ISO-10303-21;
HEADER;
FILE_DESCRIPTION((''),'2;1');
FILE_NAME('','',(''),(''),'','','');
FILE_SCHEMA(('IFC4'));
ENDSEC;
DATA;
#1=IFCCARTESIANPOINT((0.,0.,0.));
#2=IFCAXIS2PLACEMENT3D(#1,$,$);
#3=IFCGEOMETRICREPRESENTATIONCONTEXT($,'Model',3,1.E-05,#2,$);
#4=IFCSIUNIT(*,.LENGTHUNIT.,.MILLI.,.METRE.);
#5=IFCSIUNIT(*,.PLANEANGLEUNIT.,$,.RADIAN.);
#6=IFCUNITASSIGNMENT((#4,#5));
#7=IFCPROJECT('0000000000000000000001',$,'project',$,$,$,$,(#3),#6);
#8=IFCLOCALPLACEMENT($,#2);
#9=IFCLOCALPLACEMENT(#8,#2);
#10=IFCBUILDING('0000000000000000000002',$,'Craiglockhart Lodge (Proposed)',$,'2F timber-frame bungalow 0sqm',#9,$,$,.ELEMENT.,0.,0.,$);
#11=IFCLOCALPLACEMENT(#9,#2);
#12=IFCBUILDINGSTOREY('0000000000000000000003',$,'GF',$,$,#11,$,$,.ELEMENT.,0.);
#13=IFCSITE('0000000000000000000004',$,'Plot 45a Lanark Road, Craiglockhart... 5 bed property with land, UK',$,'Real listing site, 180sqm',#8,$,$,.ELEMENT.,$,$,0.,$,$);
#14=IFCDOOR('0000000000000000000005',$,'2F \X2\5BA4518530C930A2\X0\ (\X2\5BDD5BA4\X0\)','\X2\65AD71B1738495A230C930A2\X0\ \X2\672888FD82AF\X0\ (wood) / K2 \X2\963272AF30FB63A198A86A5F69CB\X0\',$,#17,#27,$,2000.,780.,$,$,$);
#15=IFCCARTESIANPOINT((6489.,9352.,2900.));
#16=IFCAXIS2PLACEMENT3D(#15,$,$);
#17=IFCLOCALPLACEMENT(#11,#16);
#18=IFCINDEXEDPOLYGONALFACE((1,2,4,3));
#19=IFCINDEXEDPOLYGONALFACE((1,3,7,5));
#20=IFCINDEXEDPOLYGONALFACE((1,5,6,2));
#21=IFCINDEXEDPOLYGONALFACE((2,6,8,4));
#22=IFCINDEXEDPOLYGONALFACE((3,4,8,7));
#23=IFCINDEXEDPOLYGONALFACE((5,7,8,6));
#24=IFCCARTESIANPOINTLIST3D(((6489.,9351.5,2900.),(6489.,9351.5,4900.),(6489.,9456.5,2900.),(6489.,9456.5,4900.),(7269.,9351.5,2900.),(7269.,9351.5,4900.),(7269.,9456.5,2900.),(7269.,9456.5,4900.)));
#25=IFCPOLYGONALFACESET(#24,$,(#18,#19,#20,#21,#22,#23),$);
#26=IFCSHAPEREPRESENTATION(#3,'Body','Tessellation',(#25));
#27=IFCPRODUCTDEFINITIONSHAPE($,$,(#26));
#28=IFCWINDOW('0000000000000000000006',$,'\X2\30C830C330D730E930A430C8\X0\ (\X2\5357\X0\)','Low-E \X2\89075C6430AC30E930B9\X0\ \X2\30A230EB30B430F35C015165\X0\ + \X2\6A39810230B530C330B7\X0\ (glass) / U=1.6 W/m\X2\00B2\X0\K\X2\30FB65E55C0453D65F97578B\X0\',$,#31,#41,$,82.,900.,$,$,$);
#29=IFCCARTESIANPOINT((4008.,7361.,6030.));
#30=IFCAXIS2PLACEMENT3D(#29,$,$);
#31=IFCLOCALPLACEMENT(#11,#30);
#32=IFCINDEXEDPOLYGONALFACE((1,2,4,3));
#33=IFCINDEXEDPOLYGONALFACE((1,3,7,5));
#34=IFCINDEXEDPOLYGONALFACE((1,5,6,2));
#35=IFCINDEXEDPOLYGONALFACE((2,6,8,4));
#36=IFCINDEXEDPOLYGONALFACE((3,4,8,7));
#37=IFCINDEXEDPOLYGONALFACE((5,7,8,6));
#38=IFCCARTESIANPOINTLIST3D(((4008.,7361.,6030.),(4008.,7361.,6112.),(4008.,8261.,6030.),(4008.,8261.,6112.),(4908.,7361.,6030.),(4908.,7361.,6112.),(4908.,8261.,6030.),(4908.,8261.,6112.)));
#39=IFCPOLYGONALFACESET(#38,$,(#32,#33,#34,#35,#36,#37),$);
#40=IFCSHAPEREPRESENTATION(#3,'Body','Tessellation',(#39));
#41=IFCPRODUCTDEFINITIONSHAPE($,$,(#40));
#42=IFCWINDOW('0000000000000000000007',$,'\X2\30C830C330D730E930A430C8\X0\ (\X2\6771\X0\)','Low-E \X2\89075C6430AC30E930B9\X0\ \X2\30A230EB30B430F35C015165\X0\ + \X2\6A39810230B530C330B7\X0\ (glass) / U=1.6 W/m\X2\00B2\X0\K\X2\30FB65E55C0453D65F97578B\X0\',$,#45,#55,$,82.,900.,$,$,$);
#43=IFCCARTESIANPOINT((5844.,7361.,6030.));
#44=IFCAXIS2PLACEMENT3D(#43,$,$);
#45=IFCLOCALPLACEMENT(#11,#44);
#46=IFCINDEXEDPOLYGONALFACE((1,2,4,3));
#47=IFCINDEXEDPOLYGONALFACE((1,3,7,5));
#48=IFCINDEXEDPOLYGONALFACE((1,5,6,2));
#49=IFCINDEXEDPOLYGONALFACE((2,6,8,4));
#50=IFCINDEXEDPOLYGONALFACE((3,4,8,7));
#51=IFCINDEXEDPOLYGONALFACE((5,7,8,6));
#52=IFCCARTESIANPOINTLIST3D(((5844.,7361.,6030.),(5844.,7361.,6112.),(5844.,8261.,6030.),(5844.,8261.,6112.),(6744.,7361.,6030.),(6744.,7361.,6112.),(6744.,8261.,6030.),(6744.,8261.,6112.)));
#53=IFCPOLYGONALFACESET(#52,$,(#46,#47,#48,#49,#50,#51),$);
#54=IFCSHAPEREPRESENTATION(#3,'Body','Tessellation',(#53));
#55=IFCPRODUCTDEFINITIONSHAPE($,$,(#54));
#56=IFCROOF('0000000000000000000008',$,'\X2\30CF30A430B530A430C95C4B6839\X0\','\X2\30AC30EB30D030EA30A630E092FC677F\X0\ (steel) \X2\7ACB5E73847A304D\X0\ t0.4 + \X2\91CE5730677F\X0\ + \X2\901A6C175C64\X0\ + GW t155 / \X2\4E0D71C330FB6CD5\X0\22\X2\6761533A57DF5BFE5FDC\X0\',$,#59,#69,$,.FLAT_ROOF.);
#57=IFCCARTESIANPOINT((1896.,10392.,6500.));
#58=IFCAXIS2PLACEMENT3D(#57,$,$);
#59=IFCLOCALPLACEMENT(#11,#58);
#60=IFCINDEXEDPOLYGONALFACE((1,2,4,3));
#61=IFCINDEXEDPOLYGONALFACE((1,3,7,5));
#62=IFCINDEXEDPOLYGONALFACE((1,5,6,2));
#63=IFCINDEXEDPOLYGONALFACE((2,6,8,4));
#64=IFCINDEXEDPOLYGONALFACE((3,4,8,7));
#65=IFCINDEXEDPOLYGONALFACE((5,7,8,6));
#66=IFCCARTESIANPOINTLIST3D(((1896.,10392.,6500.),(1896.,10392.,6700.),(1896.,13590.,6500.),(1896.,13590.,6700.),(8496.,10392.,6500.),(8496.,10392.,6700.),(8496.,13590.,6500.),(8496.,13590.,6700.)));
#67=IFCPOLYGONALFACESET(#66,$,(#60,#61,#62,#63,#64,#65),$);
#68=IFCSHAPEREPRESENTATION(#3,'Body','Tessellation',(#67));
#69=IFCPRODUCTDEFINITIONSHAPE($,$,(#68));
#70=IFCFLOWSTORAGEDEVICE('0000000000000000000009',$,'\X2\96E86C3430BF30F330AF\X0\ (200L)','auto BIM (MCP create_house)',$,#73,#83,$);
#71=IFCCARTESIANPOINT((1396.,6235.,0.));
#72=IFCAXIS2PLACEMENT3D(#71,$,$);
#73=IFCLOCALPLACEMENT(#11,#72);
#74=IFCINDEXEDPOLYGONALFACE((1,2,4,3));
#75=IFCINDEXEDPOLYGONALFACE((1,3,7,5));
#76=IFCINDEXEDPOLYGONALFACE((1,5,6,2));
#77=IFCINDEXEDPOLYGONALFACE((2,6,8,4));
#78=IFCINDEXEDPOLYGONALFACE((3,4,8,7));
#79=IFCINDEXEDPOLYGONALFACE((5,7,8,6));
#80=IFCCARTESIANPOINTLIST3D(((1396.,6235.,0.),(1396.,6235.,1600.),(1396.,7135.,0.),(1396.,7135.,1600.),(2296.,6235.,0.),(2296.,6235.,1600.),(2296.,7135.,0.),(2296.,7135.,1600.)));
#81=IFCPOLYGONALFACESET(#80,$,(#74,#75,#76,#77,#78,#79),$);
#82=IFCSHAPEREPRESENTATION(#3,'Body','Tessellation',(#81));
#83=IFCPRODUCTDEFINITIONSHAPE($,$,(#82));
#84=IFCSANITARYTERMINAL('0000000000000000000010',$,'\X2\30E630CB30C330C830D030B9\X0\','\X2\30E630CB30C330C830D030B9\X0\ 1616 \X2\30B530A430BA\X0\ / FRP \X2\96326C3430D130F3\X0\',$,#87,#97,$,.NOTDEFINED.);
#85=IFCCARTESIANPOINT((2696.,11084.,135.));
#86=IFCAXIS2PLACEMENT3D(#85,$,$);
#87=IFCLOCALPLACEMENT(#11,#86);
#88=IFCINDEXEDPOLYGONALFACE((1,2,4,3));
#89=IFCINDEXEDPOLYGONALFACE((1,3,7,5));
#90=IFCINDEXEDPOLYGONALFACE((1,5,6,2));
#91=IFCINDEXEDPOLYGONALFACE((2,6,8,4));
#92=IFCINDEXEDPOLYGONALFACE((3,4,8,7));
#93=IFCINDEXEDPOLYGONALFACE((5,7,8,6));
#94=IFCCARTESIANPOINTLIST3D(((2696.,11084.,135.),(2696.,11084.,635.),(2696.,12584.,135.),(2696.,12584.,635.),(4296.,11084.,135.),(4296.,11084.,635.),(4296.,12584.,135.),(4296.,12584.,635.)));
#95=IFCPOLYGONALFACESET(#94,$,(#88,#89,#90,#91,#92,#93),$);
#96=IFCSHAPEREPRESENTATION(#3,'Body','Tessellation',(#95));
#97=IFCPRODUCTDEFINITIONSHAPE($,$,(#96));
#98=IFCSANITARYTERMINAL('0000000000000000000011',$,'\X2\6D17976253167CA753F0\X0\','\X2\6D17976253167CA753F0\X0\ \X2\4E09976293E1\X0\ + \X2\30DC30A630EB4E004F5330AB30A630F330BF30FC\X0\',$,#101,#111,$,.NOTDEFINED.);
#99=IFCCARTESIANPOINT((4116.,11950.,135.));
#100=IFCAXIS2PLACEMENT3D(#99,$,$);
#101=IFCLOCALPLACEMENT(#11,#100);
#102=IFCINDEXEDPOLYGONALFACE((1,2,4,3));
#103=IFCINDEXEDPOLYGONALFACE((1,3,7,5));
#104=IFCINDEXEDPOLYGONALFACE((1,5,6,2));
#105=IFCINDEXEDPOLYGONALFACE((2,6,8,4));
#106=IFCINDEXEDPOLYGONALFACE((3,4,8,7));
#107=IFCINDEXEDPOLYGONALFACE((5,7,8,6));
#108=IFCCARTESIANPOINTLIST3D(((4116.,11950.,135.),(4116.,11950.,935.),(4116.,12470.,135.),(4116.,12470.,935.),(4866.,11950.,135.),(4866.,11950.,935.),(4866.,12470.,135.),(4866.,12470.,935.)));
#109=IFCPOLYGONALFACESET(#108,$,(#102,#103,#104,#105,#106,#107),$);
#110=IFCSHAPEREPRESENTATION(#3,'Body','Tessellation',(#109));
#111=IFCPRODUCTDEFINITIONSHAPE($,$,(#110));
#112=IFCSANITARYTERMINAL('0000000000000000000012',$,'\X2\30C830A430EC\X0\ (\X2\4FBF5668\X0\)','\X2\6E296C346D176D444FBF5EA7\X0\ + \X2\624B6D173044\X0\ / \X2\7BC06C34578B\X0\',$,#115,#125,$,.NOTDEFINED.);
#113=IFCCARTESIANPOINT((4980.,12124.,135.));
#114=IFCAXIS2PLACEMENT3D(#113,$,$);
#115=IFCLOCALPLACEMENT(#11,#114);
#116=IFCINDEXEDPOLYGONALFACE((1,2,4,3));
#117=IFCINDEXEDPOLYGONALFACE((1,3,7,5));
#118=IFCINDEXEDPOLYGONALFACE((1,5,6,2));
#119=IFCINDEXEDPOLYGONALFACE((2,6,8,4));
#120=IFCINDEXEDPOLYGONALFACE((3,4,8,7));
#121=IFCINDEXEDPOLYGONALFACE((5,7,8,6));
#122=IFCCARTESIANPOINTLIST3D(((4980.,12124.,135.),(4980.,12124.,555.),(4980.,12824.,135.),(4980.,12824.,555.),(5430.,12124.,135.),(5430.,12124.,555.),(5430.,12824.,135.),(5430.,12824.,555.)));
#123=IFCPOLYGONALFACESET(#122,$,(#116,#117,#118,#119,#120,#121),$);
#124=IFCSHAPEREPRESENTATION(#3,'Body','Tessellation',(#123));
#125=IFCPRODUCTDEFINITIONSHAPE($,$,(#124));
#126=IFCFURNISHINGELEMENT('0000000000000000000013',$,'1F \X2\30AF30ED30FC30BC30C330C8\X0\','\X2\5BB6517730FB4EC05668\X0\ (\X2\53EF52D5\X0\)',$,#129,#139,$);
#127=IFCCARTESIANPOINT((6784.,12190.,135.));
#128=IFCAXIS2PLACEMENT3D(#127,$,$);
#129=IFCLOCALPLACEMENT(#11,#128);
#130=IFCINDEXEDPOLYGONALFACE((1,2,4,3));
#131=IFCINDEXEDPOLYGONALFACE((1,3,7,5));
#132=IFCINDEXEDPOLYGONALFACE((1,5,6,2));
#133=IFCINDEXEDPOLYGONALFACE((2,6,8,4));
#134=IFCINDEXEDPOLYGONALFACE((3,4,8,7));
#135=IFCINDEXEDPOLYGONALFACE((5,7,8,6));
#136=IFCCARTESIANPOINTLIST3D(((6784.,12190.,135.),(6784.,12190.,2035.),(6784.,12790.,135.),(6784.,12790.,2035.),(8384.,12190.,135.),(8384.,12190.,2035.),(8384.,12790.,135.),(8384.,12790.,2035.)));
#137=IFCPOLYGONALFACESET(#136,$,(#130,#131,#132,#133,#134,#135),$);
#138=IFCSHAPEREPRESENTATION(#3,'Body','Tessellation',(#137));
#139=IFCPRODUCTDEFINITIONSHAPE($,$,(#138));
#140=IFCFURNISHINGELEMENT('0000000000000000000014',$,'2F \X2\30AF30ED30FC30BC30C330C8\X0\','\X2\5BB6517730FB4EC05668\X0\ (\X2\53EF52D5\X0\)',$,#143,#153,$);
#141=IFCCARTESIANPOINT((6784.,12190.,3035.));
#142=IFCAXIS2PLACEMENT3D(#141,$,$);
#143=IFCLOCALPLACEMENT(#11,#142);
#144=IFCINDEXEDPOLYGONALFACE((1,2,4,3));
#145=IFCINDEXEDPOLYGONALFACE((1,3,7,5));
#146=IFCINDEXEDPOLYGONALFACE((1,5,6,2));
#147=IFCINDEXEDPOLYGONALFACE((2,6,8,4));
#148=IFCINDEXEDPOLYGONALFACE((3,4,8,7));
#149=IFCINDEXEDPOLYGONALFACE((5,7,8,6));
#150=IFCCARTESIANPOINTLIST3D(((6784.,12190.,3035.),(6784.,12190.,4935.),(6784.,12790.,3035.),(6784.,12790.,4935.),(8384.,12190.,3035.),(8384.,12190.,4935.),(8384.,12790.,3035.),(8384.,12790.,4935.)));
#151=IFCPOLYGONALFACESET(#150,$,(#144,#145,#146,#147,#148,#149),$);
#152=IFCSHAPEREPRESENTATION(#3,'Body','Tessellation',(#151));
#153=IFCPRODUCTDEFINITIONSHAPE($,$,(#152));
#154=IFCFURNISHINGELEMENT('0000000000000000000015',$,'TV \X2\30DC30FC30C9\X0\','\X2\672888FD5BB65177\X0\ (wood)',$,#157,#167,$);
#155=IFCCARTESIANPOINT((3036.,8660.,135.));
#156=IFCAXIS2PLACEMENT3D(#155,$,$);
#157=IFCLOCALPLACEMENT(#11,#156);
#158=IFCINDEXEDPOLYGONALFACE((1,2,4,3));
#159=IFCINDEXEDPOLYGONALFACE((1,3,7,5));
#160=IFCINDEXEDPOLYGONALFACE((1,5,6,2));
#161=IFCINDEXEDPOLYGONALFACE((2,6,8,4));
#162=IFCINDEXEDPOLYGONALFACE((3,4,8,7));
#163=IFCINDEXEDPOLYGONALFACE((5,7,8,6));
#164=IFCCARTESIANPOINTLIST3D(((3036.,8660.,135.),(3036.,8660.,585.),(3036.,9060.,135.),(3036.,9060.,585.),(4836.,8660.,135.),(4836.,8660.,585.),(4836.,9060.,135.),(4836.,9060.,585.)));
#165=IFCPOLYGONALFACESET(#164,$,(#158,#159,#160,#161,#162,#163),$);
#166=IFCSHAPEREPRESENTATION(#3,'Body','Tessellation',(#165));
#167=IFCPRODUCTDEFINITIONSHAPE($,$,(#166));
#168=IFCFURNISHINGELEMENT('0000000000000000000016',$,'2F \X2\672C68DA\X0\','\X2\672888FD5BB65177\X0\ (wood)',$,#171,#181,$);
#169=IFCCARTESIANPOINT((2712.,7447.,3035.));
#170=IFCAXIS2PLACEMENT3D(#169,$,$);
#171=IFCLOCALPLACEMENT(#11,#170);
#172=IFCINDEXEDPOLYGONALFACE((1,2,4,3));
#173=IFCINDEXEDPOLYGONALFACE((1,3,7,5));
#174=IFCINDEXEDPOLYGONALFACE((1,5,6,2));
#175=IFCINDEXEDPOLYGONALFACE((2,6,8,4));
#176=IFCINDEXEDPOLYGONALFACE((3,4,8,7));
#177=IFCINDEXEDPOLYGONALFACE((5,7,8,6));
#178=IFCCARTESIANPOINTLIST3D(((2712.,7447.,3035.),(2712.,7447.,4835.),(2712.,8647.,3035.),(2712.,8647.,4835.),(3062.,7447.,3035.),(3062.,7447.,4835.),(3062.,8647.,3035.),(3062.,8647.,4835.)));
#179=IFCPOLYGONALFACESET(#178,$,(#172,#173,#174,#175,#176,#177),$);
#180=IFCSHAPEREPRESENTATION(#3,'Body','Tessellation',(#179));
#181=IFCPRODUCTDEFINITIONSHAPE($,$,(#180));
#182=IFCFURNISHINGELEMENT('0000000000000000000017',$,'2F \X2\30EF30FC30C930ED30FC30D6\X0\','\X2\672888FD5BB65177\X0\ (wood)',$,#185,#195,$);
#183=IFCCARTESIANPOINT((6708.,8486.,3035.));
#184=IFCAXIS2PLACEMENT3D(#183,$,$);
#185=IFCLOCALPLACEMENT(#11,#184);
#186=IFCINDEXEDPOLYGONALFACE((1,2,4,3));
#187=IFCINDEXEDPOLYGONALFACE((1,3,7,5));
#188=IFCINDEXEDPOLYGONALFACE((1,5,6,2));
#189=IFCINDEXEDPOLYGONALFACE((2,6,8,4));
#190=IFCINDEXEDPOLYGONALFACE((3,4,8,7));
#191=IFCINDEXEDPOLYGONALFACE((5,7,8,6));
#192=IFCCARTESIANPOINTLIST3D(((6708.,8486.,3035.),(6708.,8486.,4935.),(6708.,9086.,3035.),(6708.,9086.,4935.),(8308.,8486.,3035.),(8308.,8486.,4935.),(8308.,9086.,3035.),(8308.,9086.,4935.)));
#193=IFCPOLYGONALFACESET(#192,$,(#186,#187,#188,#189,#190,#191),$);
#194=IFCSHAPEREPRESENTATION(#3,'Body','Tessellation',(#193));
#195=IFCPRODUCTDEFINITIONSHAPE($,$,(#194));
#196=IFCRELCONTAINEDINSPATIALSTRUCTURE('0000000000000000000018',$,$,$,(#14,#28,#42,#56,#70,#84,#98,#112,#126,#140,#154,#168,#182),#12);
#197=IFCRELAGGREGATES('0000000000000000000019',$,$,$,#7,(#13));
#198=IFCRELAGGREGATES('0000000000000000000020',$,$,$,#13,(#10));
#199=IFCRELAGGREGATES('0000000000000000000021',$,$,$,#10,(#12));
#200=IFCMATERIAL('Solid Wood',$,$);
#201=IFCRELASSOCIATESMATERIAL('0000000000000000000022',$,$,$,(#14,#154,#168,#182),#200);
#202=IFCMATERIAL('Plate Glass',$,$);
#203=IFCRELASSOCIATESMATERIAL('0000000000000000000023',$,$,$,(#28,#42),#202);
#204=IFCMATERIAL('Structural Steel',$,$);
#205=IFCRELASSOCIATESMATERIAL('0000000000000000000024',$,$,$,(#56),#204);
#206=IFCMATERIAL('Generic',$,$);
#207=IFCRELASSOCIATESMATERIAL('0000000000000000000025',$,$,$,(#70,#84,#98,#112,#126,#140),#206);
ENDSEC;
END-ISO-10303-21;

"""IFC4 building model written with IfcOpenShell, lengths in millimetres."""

from ifc_helpers import new_model, si_unit, frame, frame_2d, origin, place, context, project, spatial, rectangle, extrude, material, element, save


model = new_model("IFC4")

# Units and contexts
model_context = context("Model", 3, precision=1e-05, world=origin())
ifc_project = project(units=[si_unit("LENGTHUNIT", "METRE", prefix="MILLI"), si_unit("PLANEANGLEUNIT", "RADIAN")], contexts=[model_context])

# Site, building, storey
site_placement = place(None, origin())
site = spatial("IfcSite", under=ifc_project, at=site_placement, Name="Plot 45a Lanark Road, Craiglockhart... 5 bed property with land, UK", ObjectType="Real listing site, 180sqm", CompositionType="ELEMENT", RefElevation=0.0)
building_placement = place(site_placement, origin())
building = spatial("IfcBuilding", under=site, at=building_placement, Name="Craiglockhart Lodge (Proposed)", ObjectType="2F timber-frame bungalow 0sqm", CompositionType="ELEMENT", ElevationOfRefHeight=0.0, ElevationOfTerrain=0.0)
storey_placement = place(building_placement, origin())
storey = spatial("IfcBuildingStorey", under=building, at=storey_placement, Name="GF", CompositionType="ELEMENT", Elevation=0.0)

# Shared definitions
ifc_material_1 = material(Name="Solid Wood")
ifc_material_2 = material(Name="Plate Glass")

# Door
door_1_placement = place(storey_placement, frame((6489.0, 9352.0, 2900.0)))
element("IfcDoor", 1, at=door_1_placement, inside=storey, material=ifc_material_1, Name="2F 室内ドア (寝室)", Description="断熱玄関ドア 木製芯 (wood) / K2 防犯・採風機構", OverallHeight=2000.0, OverallWidth=780.0, context=model_context, shape_type="SweptSolid", body=[
    extrude(rectangle(XDim=780.0, YDim=105.0, at=frame_2d((390.0, 52.0))), frame((6489.0, 9352.0, 2900.0)), (0.0, 0.0, 1.0), 2000.0),
])

# Windows
window_1_placement = place(storey_placement, frame((4008.0, 7361.0, 6030.0)))
element("IfcWindow", 2, at=window_1_placement, inside=storey, material=ifc_material_2, Name="トップライト (南)", Description="Low-E 複層ガラス アルゴン封入 + 樹脂サッシ (glass) / U=1.6 W/m²K・日射取得型", OverallHeight=82.0, OverallWidth=900.0, context=model_context, shape_type="SweptSolid", body=[
    extrude(rectangle(XDim=900.0, YDim=900.0, at=frame_2d((450.0, 450.0))), frame((4008.0, 7361.0, 6030.0)), (0.0, 0.0, 1.0), 82.0),
])
window_2_placement = place(storey_placement, frame((5844.0, 7361.0, 6030.0)))
element("IfcWindow", 3, at=window_2_placement, inside=storey, material=ifc_material_2, Name="トップライト (東)", Description="Low-E 複層ガラス アルゴン封入 + 樹脂サッシ (glass) / U=1.6 W/m²K・日射取得型", OverallHeight=82.0, OverallWidth=900.0, context=model_context, shape_type="SweptSolid", body=[
    extrude(rectangle(XDim=900.0, YDim=900.0, at=frame_2d((450.0, 450.0))), frame((5844.0, 7361.0, 6030.0)), (0.0, 0.0, 1.0), 82.0),
])

# Roof
ifc_material_3 = material(Name="Structural Steel")
roof_placement = place(storey_placement, frame((1896.0, 10392.0, 6500.0)))
element("IfcRoof", 4, at=roof_placement, inside=storey, material=ifc_material_3, Name="ハイサイド屋根", Description="ガルバリウム鋼板 (steel) 立平葺き t0.4 + 野地板 + 通気層 + GW t155 / 不燃・法22条区域対応", PredefinedType="FLAT_ROOF", context=model_context, shape_type="SweptSolid", body=[
    extrude(rectangle(XDim=6600.0, YDim=3198.0, at=frame_2d((3300.0, 1599.0))), frame((1896.0, 10392.0, 6500.0)), (0.0, 0.0, 1.0), 200.0),
])

# Flow storage device
ifc_material_4 = material(Name="Generic")
flow_storage_device_placement = place(storey_placement, frame((1396.0, 6235.0, 0.0)))
element("IfcFlowStorageDevice", 5, at=flow_storage_device_placement, inside=storey, material=ifc_material_4, Name="雨水タンク (200L)", Description="auto BIM (MCP create_house)", context=model_context, shape_type="SweptSolid", body=[
    extrude(rectangle(XDim=900.0, YDim=900.0, at=frame_2d((450.0, 450.0))), frame((1396.0, 6235.0, 0.0)), (0.0, 0.0, 1.0), 1600.0),
])

# Sanitary terminals
sanitary_terminal_1_placement = place(storey_placement, frame((2696.0, 11084.0, 135.0)))
element("IfcSanitaryTerminal", 6, at=sanitary_terminal_1_placement, inside=storey, material=ifc_material_4, Name="ユニットバス", Description="ユニットバス 1616 サイズ / FRP 防水パン", PredefinedType="NOTDEFINED", context=model_context, shape_type="SweptSolid", body=[
    extrude(rectangle(XDim=1600.0, YDim=1500.0, at=frame_2d((800.0, 750.0))), frame((2696.0, 11084.0, 135.0)), (0.0, 0.0, 1.0), 500.0),
])
sanitary_terminal_2_placement = place(storey_placement, frame((4116.0, 11950.0, 135.0)))
element("IfcSanitaryTerminal", 7, at=sanitary_terminal_2_placement, inside=storey, material=ifc_material_4, Name="洗面化粧台", Description="洗面化粧台 三面鏡 + ボウル一体カウンター", PredefinedType="NOTDEFINED", context=model_context, shape_type="SweptSolid", body=[
    extrude(rectangle(XDim=750.0, YDim=520.0, at=frame_2d((375.0, 260.0))), frame((4116.0, 11950.0, 135.0)), (0.0, 0.0, 1.0), 800.0),
])
sanitary_terminal_3_placement = place(storey_placement, frame((4980.0, 12124.0, 135.0)))
element("IfcSanitaryTerminal", 8, at=sanitary_terminal_3_placement, inside=storey, material=ifc_material_4, Name="トイレ (便器)", Description="温水洗浄便座 + 手洗い / 節水型", PredefinedType="NOTDEFINED", context=model_context, shape_type="SweptSolid", body=[
    extrude(rectangle(XDim=450.0, YDim=700.0, at=frame_2d((225.0, 350.0))), frame((4980.0, 12124.0, 135.0)), (0.0, 0.0, 1.0), 420.0),
])

# Furnishing elements
furnishing_1_placement = place(storey_placement, frame((6784.0, 12190.0, 135.0)))
element("IfcFurnishingElement", 9, at=furnishing_1_placement, inside=storey, material=ifc_material_4, Name="1F クローゼット", Description="家具・什器 (可動)", context=model_context, shape_type="SweptSolid", body=[
    extrude(rectangle(XDim=1600.0, YDim=600.0, at=frame_2d((800.0, 300.0))), frame((6784.0, 12190.0, 135.0)), (0.0, 0.0, 1.0), 1900.0),
])
furnishing_2_placement = place(storey_placement, frame((6784.0, 12190.0, 3035.0)))
element("IfcFurnishingElement", 10, at=furnishing_2_placement, inside=storey, material=ifc_material_4, Name="2F クローゼット", Description="家具・什器 (可動)", context=model_context, shape_type="SweptSolid", body=[
    extrude(rectangle(XDim=1600.0, YDim=600.0, at=frame_2d((800.0, 300.0))), frame((6784.0, 12190.0, 3035.0)), (0.0, 0.0, 1.0), 1900.0),
])
furnishing_3_placement = place(storey_placement, frame((3036.0, 8660.0, 135.0)))
element("IfcFurnishingElement", 11, at=furnishing_3_placement, inside=storey, material=ifc_material_1, Name="TV ボード", Description="木製家具 (wood)", context=model_context, shape_type="SweptSolid", body=[
    extrude(rectangle(XDim=1800.0, YDim=400.0, at=frame_2d((900.0, 200.0))), frame((3036.0, 8660.0, 135.0)), (0.0, 0.0, 1.0), 450.0),
])
furnishing_4_placement = place(storey_placement, frame((2712.0, 7447.0, 3035.0)))
element("IfcFurnishingElement", 12, at=furnishing_4_placement, inside=storey, material=ifc_material_1, Name="2F 本棚", Description="木製家具 (wood)", context=model_context, shape_type="SweptSolid", body=[
    extrude(rectangle(XDim=350.0, YDim=1200.0, at=frame_2d((175.0, 600.0))), frame((2712.0, 7447.0, 3035.0)), (0.0, 0.0, 1.0), 1800.0),
])
furnishing_5_placement = place(storey_placement, frame((6708.0, 8486.0, 3035.0)))
element("IfcFurnishingElement", 13, at=furnishing_5_placement, inside=storey, material=ifc_material_1, Name="2F ワードローブ", Description="木製家具 (wood)", context=model_context, shape_type="SweptSolid", body=[
    extrude(rectangle(XDim=1600.0, YDim=600.0, at=frame_2d((800.0, 300.0))), frame((6708.0, 8486.0, 3035.0)), (0.0, 0.0, 1.0), 1900.0),
])

save(model, "model.ifc")
